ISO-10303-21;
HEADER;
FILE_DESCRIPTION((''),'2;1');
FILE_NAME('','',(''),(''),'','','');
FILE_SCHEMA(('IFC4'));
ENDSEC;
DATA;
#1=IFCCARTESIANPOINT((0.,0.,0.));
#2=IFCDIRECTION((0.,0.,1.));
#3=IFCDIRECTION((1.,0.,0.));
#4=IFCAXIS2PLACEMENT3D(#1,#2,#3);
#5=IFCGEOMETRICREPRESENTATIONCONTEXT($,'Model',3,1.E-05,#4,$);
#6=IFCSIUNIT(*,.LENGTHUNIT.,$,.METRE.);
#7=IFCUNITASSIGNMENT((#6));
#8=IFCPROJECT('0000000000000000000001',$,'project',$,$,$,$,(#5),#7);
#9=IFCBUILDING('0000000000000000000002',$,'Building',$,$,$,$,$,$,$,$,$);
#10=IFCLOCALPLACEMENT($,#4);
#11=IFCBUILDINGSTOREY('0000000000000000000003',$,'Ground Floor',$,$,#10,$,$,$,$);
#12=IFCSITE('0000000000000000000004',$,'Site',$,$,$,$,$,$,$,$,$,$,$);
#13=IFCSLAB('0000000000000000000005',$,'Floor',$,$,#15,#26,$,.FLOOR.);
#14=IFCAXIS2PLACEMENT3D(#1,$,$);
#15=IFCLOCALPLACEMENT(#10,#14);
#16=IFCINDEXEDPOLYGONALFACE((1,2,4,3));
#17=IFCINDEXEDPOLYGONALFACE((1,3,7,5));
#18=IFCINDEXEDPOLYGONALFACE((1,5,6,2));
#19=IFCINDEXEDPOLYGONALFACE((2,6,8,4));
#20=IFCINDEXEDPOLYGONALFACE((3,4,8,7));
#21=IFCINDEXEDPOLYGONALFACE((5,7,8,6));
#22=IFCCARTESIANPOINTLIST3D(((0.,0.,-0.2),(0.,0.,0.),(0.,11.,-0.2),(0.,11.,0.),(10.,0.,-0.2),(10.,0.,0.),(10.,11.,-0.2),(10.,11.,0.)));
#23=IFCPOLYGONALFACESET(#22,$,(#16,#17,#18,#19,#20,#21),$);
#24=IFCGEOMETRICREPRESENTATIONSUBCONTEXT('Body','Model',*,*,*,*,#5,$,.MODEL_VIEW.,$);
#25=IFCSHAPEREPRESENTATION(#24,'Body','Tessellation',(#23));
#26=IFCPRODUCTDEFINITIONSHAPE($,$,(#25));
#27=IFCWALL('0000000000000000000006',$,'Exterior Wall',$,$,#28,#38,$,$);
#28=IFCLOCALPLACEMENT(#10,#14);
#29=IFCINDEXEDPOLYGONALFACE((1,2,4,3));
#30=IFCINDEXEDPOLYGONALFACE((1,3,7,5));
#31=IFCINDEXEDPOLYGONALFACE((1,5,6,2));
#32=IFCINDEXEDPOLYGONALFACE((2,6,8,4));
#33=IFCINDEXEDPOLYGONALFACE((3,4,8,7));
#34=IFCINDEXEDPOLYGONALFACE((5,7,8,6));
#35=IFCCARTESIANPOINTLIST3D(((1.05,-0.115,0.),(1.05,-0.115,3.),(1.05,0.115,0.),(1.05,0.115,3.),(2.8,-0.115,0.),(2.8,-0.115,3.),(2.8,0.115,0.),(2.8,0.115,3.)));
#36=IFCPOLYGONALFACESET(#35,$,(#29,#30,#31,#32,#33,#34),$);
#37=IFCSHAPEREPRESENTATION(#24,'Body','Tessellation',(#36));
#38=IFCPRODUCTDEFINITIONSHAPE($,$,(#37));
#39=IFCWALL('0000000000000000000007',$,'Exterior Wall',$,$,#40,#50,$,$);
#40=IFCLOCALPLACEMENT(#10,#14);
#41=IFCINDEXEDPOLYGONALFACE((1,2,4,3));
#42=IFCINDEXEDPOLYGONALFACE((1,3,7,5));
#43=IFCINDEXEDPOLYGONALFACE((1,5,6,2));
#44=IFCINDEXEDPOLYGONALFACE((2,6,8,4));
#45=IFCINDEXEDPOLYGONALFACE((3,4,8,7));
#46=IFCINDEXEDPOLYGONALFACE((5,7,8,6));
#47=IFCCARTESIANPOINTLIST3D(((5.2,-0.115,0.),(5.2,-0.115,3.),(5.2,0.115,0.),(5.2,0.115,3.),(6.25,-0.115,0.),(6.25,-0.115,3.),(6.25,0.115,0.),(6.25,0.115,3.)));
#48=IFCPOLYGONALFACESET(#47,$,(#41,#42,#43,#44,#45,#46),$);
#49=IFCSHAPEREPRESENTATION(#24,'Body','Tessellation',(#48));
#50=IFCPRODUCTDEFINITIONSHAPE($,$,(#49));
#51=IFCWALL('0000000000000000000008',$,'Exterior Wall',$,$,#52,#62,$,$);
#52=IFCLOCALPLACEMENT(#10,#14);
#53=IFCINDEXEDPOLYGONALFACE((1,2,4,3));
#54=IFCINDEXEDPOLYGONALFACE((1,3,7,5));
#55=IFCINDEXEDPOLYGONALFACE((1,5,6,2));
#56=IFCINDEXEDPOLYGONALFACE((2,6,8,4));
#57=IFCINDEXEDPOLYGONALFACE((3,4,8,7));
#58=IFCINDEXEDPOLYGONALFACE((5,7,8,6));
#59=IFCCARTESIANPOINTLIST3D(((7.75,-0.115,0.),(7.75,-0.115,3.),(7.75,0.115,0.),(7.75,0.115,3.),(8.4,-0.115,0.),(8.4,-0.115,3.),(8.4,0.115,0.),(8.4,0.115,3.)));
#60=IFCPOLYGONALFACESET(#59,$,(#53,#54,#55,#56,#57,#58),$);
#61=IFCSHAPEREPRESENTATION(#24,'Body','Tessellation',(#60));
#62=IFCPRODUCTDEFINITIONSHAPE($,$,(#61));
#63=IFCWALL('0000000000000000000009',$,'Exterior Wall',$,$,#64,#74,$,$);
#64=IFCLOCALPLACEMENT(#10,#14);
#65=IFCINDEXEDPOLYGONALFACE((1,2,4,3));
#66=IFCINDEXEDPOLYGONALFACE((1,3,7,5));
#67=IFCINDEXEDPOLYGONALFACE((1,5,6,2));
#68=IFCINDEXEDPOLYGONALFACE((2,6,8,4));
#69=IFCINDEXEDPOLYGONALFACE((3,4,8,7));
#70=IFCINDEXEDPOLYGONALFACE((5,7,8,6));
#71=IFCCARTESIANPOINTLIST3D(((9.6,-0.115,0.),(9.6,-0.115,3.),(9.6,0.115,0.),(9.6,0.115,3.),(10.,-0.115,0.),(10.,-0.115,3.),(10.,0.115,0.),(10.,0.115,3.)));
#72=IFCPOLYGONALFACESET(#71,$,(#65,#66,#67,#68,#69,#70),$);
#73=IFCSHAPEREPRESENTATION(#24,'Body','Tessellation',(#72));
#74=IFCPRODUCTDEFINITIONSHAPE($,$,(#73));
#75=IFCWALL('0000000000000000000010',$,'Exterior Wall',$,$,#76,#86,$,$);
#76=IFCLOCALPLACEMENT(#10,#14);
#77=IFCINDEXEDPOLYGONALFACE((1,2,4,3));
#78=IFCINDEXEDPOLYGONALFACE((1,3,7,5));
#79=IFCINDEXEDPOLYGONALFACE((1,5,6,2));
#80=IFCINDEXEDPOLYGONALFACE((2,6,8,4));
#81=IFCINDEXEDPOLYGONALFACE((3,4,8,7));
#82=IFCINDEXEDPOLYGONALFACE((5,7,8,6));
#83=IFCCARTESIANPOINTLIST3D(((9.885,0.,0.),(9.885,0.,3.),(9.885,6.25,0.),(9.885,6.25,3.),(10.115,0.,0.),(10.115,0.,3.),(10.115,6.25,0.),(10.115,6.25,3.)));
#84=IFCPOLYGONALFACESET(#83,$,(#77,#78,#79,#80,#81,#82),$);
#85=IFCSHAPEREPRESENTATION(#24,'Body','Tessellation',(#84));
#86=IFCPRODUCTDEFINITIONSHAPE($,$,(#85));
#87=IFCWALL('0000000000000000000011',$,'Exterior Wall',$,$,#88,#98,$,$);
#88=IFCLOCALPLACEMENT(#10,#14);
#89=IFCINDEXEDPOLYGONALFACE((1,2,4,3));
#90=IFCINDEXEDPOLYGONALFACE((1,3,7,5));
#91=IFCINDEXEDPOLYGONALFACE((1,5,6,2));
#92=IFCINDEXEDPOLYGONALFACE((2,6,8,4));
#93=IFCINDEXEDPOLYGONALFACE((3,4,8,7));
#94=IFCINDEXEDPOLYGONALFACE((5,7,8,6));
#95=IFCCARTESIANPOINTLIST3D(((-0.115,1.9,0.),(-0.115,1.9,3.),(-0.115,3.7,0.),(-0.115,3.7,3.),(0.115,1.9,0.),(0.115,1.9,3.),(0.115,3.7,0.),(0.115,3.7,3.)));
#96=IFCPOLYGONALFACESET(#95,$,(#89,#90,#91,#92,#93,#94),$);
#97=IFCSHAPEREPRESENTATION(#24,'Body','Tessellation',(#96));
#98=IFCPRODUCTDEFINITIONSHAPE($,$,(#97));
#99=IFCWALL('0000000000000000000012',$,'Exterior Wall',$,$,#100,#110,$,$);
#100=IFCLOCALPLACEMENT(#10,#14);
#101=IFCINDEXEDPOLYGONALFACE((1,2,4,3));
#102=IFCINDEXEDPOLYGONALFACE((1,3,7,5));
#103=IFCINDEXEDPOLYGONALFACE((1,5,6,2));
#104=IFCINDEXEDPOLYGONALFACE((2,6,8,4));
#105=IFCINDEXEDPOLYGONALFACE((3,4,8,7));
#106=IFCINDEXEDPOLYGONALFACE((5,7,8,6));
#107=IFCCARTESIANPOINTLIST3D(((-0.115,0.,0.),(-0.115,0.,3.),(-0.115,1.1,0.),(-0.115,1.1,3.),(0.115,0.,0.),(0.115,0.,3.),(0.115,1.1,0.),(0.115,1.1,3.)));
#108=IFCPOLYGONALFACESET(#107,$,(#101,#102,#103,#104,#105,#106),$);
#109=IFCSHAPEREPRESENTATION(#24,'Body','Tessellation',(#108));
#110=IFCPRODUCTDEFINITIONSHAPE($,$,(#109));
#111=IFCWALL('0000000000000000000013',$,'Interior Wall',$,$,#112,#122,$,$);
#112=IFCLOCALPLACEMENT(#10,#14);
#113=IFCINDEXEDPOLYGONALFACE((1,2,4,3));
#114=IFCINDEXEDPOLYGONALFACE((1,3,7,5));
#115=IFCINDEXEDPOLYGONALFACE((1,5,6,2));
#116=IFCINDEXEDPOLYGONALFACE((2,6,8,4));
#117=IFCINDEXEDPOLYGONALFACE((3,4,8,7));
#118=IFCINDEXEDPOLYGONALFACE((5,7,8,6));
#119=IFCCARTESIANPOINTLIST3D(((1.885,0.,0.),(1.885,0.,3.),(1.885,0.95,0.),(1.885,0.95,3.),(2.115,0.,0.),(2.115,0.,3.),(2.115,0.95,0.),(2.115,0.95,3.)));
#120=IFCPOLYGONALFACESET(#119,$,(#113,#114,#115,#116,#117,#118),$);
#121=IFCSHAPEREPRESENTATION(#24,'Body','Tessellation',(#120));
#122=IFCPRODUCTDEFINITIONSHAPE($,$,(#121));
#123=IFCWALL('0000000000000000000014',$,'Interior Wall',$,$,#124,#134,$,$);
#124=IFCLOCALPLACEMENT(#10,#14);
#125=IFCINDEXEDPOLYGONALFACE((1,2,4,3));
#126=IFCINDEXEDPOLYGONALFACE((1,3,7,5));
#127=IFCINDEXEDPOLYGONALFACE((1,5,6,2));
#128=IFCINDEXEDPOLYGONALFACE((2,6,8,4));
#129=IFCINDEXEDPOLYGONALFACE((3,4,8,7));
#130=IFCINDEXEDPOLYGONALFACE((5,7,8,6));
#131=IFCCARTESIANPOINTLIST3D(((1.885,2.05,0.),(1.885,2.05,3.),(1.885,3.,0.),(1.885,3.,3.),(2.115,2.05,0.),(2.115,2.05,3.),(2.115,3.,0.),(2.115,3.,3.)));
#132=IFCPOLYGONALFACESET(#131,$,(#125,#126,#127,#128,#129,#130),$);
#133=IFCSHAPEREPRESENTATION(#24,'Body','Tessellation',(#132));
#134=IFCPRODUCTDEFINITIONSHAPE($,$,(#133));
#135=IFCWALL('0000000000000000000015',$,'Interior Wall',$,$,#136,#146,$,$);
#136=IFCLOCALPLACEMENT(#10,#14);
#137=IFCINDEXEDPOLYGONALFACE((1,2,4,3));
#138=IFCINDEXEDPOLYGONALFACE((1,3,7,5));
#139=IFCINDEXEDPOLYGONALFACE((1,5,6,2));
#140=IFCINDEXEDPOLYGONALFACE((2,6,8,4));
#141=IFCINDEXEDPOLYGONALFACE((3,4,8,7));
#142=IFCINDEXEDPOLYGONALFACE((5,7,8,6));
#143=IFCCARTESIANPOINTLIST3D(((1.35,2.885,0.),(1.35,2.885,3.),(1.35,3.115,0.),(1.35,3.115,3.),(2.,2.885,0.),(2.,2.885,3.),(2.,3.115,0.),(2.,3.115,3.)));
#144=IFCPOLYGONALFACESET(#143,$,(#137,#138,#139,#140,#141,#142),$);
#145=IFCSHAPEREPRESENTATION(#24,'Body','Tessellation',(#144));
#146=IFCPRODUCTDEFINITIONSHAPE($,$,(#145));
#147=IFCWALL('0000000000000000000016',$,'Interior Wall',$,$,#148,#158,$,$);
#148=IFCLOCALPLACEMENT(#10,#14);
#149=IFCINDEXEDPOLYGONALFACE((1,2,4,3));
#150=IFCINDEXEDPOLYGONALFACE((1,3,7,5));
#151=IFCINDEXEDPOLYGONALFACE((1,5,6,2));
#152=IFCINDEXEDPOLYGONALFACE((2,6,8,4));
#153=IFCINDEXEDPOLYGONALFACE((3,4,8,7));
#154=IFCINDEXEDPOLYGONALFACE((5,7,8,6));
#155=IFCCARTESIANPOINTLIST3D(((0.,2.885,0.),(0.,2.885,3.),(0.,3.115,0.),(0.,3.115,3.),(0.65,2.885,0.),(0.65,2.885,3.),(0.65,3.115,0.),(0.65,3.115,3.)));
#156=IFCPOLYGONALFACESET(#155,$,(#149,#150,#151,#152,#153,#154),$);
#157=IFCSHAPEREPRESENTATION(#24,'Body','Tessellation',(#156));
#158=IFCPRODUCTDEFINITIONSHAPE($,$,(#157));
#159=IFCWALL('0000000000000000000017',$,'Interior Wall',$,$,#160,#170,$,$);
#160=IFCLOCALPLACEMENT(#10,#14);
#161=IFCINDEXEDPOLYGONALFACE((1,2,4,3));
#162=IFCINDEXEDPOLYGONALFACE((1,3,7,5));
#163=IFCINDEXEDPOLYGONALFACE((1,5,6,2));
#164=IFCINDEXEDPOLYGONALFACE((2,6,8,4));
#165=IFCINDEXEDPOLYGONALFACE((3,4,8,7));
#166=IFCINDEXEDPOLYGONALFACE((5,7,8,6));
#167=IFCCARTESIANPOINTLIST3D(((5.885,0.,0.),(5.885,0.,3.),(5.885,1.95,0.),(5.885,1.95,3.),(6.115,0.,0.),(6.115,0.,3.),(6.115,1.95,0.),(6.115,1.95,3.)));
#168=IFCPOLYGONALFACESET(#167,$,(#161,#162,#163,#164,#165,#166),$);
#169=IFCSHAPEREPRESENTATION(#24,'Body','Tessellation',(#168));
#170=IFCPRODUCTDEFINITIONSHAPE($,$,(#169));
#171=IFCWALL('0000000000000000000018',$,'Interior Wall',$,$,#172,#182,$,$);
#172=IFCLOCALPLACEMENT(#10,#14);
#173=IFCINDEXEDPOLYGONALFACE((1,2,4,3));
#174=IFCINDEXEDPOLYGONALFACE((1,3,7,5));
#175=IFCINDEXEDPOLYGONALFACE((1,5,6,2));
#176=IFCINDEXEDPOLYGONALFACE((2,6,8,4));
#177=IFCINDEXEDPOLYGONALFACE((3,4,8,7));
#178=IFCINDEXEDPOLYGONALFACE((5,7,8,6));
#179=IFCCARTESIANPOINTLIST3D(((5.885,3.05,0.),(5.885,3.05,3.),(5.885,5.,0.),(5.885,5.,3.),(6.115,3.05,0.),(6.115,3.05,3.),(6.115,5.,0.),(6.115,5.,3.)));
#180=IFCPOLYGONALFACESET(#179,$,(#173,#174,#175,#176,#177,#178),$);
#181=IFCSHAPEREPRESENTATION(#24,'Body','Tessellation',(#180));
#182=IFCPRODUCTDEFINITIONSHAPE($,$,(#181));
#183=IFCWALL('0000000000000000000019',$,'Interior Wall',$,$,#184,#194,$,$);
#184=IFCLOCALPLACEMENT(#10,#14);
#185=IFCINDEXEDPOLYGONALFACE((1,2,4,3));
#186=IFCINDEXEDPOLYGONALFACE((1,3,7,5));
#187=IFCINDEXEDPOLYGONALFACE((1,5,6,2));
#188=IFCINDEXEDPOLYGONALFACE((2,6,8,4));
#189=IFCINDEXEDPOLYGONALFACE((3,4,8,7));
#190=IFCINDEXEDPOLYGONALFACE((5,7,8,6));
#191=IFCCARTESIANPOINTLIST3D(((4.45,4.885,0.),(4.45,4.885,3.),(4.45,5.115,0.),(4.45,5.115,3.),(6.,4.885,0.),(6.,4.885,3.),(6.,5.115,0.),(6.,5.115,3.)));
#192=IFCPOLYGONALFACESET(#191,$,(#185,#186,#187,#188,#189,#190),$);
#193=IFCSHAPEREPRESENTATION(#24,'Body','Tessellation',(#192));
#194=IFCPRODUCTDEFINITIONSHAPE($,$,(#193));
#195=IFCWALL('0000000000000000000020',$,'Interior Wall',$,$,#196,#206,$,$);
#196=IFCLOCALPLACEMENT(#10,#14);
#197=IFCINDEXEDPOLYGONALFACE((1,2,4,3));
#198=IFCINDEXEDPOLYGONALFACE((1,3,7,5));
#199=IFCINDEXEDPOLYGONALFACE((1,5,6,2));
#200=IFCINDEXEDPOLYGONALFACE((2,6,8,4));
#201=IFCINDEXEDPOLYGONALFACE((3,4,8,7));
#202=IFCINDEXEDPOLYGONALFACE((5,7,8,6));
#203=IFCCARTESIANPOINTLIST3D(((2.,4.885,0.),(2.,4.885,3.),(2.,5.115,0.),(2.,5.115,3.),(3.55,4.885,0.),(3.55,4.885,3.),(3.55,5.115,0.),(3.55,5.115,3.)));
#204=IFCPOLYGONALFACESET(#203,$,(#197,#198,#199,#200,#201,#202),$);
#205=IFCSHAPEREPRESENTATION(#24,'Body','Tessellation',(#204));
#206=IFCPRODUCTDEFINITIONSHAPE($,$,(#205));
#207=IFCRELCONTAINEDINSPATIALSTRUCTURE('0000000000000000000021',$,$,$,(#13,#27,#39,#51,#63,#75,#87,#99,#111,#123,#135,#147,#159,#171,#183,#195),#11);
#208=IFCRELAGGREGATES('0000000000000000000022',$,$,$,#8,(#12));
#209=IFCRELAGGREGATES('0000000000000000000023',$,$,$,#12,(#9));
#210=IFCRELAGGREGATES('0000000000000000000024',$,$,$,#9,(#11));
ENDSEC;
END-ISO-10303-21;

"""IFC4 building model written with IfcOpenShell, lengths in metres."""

from ifc_helpers import new_model, si_unit, frame, origin_with_axes, place, context, subcontext, project, spatial, indexed_curve, outline, extrude, element, save


model = new_model("IFC4")

# Units and contexts
model_context = context("Model", 3, precision=1e-05, world=origin_with_axes())
body_context = subcontext(model_context, "Body", "Model", "MODEL_VIEW")
ifc_project = project(units=[si_unit("LENGTHUNIT", "METRE")], contexts=[model_context])

# Site, building, storey
site = spatial("IfcSite", under=ifc_project, Name="Site")
building = spatial("IfcBuilding", under=site, Name="Building")
storey_placement = place(None, origin_with_axes())
storey = spatial("IfcBuildingStorey", under=building, at=storey_placement, Name="Ground Floor")

# Slab
slab_placement = place(storey_placement, frame((0.0, 0.0, -0.2), z_axis=(0.0, 0.0, 1.0), x_axis=(1.0, 0.0, 0.0)))
element("IfcSlab", 1, at=slab_placement, inside=storey, Name="Floor", PredefinedType="FLOOR", context=body_context, shape_type="SweptSolid", body=[
    extrude(outline(indexed_curve([(0.0, 0.0), (10.0, 0.0), (10.0, 11.0), (0.0, 11.0)])), None, (0.0, 0.0, 1.0), 0.2),
])

# Walls
wall_1_placement = place(storey_placement, frame((1.05, 0.0, 0.0), z_axis=(0.0, 0.0, 1.0), x_axis=(1.0, 0.0, 0.0)))
element("IfcWall", 2, at=wall_1_placement, inside=storey, Name="Exterior Wall", context=body_context, shape_type="SweptSolid", body=[
    extrude(outline(indexed_curve([(0.0, 0.0), (0.0, 0.23), (1.75, 0.23), (1.75, 0.0), (0.0, 0.0)], self_intersect=False)), frame((0.0, -0.115, 0.0), z_axis=(0.0, 0.0, 1.0), x_axis=(1.0, 0.0, 0.0)), (0.0, 0.0, 1.0), 3.0),
])
wall_2_placement = place(storey_placement, frame((5.2, 0.0, 0.0), z_axis=(0.0, 0.0, 1.0), x_axis=(1.0, 0.0, 0.0)))
element("IfcWall", 3, at=wall_2_placement, inside=storey, Name="Exterior Wall", context=body_context, shape_type="SweptSolid", body=[
    extrude(outline(indexed_curve([(0.0, 0.0), (0.0, 0.23), (1.05, 0.23), (1.05, 0.0), (0.0, 0.0)], self_intersect=False)), frame((0.0, -0.115, 0.0), z_axis=(0.0, 0.0, 1.0), x_axis=(1.0, 0.0, 0.0)), (0.0, 0.0, 1.0), 3.0),
])
wall_3_placement = place(storey_placement, frame((7.75, 0.0, 0.0), z_axis=(0.0, 0.0, 1.0), x_axis=(1.0, 0.0, 0.0)))
element("IfcWall", 4, at=wall_3_placement, inside=storey, Name="Exterior Wall", context=body_context, shape_type="SweptSolid", body=[
    extrude(outline(indexed_curve([(0.0, 0.0), (0.0, 0.23), (0.65, 0.23), (0.65, 0.0), (0.0, 0.0)], self_intersect=False)), frame((0.0, -0.115, 0.0), z_axis=(0.0, 0.0, 1.0), x_axis=(1.0, 0.0, 0.0)), (0.0, 0.0, 1.0), 3.0),
])
wall_4_placement = place(storey_placement, frame((9.6, 0.0, 0.0), z_axis=(0.0, 0.0, 1.0), x_axis=(1.0, 0.0, 0.0)))
element("IfcWall", 5, at=wall_4_placement, inside=storey, Name="Exterior Wall", context=body_context, shape_type="SweptSolid", body=[
    extrude(outline(indexed_curve([(0.0, 0.0), (0.0, 0.23), (0.4, 0.23), (0.4, 0.0), (0.0, 0.0)], self_intersect=False)), frame((0.0, -0.115, 0.0), z_axis=(0.0, 0.0, 1.0), x_axis=(1.0, 0.0, 0.0)), (0.0, 0.0, 1.0), 3.0),
])
wall_5_placement = place(storey_placement, frame((10.0, 0.0, 0.0), z_axis=(0.0, 0.0, 1.0), x_axis=(0.0, 1.0, 0.0)))
element("IfcWall", 6, at=wall_5_placement, inside=storey, Name="Exterior Wall", context=body_context, shape_type="SweptSolid", body=[
    extrude(outline(indexed_curve([(0.0, 0.0), (0.0, 0.23), (6.25, 0.23), (6.25, 0.0), (0.0, 0.0)], self_intersect=False)), frame((0.0, -0.115, 0.0), z_axis=(0.0, 0.0, 1.0), x_axis=(1.0, 0.0, 0.0)), (0.0, 0.0, 1.0), 3.0),
])
wall_6_placement = place(storey_placement, frame((0.0, 3.7, 0.0), z_axis=(0.0, 0.0, 1.0), x_axis=(0.0, -1.0, 0.0)))
element("IfcWall", 7, at=wall_6_placement, inside=storey, Name="Exterior Wall", context=body_context, shape_type="SweptSolid", body=[
    extrude(outline(indexed_curve([(0.0, 0.0), (0.0, 0.23), (1.8, 0.23), (1.8, 0.0), (0.0, 0.0)], self_intersect=False)), frame((0.0, -0.115, 0.0), z_axis=(0.0, 0.0, 1.0), x_axis=(1.0, 0.0, 0.0)), (0.0, 0.0, 1.0), 3.0),
])
wall_7_placement = place(storey_placement, frame((0.0, 1.1, 0.0), z_axis=(0.0, 0.0, 1.0), x_axis=(0.0, -1.0, 0.0)))
element("IfcWall", 8, at=wall_7_placement, inside=storey, Name="Exterior Wall", context=body_context, shape_type="SweptSolid", body=[
    extrude(outline(indexed_curve([(0.0, 0.0), (0.0, 0.23), (1.1, 0.23), (1.1, 0.0), (0.0, 0.0)], self_intersect=False)), frame((0.0, -0.115, 0.0), z_axis=(0.0, 0.0, 1.0), x_axis=(1.0, 0.0, 0.0)), (0.0, 0.0, 1.0), 3.0),
])
wall_8_placement = place(storey_placement, frame((2.0, 0.0, 0.0), z_axis=(0.0, 0.0, 1.0), x_axis=(0.0, 1.0, 0.0)))
element("IfcWall", 9, at=wall_8_placement, inside=storey, Name="Interior Wall", context=body_context, shape_type="SweptSolid", body=[
    extrude(outline(indexed_curve([(0.0, 0.0), (0.0, 0.23), (0.95, 0.23), (0.95, 0.0), (0.0, 0.0)], self_intersect=False)), frame((0.0, -0.115, 0.0), z_axis=(0.0, 0.0, 1.0), x_axis=(1.0, 0.0, 0.0)), (0.0, 0.0, 1.0), 3.0),
])
wall_9_placement = place(storey_placement, frame((2.0, 2.05, 0.0), z_axis=(0.0, 0.0, 1.0), x_axis=(0.0, 1.0, 0.0)))
element("IfcWall", 10, at=wall_9_placement, inside=storey, Name="Interior Wall", context=body_context, shape_type="SweptSolid", body=[
    extrude(outline(indexed_curve([(0.0, 0.0), (0.0, 0.23), (0.95, 0.23), (0.95, 0.0), (0.0, 0.0)], self_intersect=False)), frame((0.0, -0.115, 0.0), z_axis=(0.0, 0.0, 1.0), x_axis=(1.0, 0.0, 0.0)), (0.0, 0.0, 1.0), 3.0),
])
for number, where, z_axis, x_axis, name in (
    (11, (2.0, 3.0, 0.0), (0.0, 0.0, 1.0), (-1.0, 0.0, 0.0), "Interior Wall"),
    (12, (0.65, 3.0, 0.0), (0.0, 0.0, 1.0), (-1.0, 0.0, 0.0), "Interior Wall"),
):
    element("IfcWall", number, at=place(storey_placement, frame(where, z_axis=z_axis, x_axis=x_axis)), inside=storey, Name=name, context=body_context, shape_type="SweptSolid", body=[
        extrude(outline(indexed_curve([(0.0, 0.0), (0.0, 0.23), (0.65, 0.23), (0.65, 0.0), (0.0, 0.0)], self_intersect=False)), frame((0.0, -0.115, 0.0), z_axis=(0.0, 0.0, 1.0), x_axis=(1.0, 0.0, 0.0)), (0.0, 0.0, 1.0), 3.0),
    ])
wall_10_placement = place(storey_placement, frame((6.0, 0.0, 0.0), z_axis=(0.0, 0.0, 1.0), x_axis=(0.0, 1.0, 0.0)))
element("IfcWall", 13, at=wall_10_placement, inside=storey, Name="Interior Wall", context=body_context, shape_type="SweptSolid", body=[
    extrude(outline(indexed_curve([(0.0, 0.0), (0.0, 0.23), (1.95, 0.23), (1.95, 0.0), (0.0, 0.0)], self_intersect=False)), frame((0.0, -0.115, 0.0), z_axis=(0.0, 0.0, 1.0), x_axis=(1.0, 0.0, 0.0)), (0.0, 0.0, 1.0), 3.0),
])
wall_11_placement = place(storey_placement, frame((6.0, 3.05, 0.0), z_axis=(0.0, 0.0, 1.0), x_axis=(0.0, 1.0, 0.0)))
element("IfcWall", 14, at=wall_11_placement, inside=storey, Name="Interior Wall", context=body_context, shape_type="SweptSolid", body=[
    extrude(outline(indexed_curve([(0.0, 0.0), (0.0, 0.23), (1.95, 0.23), (1.95, 0.0), (0.0, 0.0)], self_intersect=False)), frame((0.0, -0.115, 0.0), z_axis=(0.0, 0.0, 1.0), x_axis=(1.0, 0.0, 0.0)), (0.0, 0.0, 1.0), 3.0),
])
for number, where, z_axis, x_axis, name in (
    (15, (6.0, 5.0, 0.0), (0.0, 0.0, 1.0), (-1.0, 0.0, 0.0), "Interior Wall"),
    (16, (3.55, 5.0, 0.0), (0.0, 0.0, 1.0), (-1.0, 0.0, 0.0), "Interior Wall"),
):
    element("IfcWall", number, at=place(storey_placement, frame(where, z_axis=z_axis, x_axis=x_axis)), inside=storey, Name=name, context=body_context, shape_type="SweptSolid", body=[
        extrude(outline(indexed_curve([(0.0, 0.0), (0.0, 0.23), (1.55, 0.23), (1.55, 0.0), (0.0, 0.0)], self_intersect=False)), frame((0.0, -0.115, 0.0), z_axis=(0.0, 0.0, 1.0), x_axis=(1.0, 0.0, 0.0)), (0.0, 0.0, 1.0), 3.0),
    ])

save(model, "model.ifc")
